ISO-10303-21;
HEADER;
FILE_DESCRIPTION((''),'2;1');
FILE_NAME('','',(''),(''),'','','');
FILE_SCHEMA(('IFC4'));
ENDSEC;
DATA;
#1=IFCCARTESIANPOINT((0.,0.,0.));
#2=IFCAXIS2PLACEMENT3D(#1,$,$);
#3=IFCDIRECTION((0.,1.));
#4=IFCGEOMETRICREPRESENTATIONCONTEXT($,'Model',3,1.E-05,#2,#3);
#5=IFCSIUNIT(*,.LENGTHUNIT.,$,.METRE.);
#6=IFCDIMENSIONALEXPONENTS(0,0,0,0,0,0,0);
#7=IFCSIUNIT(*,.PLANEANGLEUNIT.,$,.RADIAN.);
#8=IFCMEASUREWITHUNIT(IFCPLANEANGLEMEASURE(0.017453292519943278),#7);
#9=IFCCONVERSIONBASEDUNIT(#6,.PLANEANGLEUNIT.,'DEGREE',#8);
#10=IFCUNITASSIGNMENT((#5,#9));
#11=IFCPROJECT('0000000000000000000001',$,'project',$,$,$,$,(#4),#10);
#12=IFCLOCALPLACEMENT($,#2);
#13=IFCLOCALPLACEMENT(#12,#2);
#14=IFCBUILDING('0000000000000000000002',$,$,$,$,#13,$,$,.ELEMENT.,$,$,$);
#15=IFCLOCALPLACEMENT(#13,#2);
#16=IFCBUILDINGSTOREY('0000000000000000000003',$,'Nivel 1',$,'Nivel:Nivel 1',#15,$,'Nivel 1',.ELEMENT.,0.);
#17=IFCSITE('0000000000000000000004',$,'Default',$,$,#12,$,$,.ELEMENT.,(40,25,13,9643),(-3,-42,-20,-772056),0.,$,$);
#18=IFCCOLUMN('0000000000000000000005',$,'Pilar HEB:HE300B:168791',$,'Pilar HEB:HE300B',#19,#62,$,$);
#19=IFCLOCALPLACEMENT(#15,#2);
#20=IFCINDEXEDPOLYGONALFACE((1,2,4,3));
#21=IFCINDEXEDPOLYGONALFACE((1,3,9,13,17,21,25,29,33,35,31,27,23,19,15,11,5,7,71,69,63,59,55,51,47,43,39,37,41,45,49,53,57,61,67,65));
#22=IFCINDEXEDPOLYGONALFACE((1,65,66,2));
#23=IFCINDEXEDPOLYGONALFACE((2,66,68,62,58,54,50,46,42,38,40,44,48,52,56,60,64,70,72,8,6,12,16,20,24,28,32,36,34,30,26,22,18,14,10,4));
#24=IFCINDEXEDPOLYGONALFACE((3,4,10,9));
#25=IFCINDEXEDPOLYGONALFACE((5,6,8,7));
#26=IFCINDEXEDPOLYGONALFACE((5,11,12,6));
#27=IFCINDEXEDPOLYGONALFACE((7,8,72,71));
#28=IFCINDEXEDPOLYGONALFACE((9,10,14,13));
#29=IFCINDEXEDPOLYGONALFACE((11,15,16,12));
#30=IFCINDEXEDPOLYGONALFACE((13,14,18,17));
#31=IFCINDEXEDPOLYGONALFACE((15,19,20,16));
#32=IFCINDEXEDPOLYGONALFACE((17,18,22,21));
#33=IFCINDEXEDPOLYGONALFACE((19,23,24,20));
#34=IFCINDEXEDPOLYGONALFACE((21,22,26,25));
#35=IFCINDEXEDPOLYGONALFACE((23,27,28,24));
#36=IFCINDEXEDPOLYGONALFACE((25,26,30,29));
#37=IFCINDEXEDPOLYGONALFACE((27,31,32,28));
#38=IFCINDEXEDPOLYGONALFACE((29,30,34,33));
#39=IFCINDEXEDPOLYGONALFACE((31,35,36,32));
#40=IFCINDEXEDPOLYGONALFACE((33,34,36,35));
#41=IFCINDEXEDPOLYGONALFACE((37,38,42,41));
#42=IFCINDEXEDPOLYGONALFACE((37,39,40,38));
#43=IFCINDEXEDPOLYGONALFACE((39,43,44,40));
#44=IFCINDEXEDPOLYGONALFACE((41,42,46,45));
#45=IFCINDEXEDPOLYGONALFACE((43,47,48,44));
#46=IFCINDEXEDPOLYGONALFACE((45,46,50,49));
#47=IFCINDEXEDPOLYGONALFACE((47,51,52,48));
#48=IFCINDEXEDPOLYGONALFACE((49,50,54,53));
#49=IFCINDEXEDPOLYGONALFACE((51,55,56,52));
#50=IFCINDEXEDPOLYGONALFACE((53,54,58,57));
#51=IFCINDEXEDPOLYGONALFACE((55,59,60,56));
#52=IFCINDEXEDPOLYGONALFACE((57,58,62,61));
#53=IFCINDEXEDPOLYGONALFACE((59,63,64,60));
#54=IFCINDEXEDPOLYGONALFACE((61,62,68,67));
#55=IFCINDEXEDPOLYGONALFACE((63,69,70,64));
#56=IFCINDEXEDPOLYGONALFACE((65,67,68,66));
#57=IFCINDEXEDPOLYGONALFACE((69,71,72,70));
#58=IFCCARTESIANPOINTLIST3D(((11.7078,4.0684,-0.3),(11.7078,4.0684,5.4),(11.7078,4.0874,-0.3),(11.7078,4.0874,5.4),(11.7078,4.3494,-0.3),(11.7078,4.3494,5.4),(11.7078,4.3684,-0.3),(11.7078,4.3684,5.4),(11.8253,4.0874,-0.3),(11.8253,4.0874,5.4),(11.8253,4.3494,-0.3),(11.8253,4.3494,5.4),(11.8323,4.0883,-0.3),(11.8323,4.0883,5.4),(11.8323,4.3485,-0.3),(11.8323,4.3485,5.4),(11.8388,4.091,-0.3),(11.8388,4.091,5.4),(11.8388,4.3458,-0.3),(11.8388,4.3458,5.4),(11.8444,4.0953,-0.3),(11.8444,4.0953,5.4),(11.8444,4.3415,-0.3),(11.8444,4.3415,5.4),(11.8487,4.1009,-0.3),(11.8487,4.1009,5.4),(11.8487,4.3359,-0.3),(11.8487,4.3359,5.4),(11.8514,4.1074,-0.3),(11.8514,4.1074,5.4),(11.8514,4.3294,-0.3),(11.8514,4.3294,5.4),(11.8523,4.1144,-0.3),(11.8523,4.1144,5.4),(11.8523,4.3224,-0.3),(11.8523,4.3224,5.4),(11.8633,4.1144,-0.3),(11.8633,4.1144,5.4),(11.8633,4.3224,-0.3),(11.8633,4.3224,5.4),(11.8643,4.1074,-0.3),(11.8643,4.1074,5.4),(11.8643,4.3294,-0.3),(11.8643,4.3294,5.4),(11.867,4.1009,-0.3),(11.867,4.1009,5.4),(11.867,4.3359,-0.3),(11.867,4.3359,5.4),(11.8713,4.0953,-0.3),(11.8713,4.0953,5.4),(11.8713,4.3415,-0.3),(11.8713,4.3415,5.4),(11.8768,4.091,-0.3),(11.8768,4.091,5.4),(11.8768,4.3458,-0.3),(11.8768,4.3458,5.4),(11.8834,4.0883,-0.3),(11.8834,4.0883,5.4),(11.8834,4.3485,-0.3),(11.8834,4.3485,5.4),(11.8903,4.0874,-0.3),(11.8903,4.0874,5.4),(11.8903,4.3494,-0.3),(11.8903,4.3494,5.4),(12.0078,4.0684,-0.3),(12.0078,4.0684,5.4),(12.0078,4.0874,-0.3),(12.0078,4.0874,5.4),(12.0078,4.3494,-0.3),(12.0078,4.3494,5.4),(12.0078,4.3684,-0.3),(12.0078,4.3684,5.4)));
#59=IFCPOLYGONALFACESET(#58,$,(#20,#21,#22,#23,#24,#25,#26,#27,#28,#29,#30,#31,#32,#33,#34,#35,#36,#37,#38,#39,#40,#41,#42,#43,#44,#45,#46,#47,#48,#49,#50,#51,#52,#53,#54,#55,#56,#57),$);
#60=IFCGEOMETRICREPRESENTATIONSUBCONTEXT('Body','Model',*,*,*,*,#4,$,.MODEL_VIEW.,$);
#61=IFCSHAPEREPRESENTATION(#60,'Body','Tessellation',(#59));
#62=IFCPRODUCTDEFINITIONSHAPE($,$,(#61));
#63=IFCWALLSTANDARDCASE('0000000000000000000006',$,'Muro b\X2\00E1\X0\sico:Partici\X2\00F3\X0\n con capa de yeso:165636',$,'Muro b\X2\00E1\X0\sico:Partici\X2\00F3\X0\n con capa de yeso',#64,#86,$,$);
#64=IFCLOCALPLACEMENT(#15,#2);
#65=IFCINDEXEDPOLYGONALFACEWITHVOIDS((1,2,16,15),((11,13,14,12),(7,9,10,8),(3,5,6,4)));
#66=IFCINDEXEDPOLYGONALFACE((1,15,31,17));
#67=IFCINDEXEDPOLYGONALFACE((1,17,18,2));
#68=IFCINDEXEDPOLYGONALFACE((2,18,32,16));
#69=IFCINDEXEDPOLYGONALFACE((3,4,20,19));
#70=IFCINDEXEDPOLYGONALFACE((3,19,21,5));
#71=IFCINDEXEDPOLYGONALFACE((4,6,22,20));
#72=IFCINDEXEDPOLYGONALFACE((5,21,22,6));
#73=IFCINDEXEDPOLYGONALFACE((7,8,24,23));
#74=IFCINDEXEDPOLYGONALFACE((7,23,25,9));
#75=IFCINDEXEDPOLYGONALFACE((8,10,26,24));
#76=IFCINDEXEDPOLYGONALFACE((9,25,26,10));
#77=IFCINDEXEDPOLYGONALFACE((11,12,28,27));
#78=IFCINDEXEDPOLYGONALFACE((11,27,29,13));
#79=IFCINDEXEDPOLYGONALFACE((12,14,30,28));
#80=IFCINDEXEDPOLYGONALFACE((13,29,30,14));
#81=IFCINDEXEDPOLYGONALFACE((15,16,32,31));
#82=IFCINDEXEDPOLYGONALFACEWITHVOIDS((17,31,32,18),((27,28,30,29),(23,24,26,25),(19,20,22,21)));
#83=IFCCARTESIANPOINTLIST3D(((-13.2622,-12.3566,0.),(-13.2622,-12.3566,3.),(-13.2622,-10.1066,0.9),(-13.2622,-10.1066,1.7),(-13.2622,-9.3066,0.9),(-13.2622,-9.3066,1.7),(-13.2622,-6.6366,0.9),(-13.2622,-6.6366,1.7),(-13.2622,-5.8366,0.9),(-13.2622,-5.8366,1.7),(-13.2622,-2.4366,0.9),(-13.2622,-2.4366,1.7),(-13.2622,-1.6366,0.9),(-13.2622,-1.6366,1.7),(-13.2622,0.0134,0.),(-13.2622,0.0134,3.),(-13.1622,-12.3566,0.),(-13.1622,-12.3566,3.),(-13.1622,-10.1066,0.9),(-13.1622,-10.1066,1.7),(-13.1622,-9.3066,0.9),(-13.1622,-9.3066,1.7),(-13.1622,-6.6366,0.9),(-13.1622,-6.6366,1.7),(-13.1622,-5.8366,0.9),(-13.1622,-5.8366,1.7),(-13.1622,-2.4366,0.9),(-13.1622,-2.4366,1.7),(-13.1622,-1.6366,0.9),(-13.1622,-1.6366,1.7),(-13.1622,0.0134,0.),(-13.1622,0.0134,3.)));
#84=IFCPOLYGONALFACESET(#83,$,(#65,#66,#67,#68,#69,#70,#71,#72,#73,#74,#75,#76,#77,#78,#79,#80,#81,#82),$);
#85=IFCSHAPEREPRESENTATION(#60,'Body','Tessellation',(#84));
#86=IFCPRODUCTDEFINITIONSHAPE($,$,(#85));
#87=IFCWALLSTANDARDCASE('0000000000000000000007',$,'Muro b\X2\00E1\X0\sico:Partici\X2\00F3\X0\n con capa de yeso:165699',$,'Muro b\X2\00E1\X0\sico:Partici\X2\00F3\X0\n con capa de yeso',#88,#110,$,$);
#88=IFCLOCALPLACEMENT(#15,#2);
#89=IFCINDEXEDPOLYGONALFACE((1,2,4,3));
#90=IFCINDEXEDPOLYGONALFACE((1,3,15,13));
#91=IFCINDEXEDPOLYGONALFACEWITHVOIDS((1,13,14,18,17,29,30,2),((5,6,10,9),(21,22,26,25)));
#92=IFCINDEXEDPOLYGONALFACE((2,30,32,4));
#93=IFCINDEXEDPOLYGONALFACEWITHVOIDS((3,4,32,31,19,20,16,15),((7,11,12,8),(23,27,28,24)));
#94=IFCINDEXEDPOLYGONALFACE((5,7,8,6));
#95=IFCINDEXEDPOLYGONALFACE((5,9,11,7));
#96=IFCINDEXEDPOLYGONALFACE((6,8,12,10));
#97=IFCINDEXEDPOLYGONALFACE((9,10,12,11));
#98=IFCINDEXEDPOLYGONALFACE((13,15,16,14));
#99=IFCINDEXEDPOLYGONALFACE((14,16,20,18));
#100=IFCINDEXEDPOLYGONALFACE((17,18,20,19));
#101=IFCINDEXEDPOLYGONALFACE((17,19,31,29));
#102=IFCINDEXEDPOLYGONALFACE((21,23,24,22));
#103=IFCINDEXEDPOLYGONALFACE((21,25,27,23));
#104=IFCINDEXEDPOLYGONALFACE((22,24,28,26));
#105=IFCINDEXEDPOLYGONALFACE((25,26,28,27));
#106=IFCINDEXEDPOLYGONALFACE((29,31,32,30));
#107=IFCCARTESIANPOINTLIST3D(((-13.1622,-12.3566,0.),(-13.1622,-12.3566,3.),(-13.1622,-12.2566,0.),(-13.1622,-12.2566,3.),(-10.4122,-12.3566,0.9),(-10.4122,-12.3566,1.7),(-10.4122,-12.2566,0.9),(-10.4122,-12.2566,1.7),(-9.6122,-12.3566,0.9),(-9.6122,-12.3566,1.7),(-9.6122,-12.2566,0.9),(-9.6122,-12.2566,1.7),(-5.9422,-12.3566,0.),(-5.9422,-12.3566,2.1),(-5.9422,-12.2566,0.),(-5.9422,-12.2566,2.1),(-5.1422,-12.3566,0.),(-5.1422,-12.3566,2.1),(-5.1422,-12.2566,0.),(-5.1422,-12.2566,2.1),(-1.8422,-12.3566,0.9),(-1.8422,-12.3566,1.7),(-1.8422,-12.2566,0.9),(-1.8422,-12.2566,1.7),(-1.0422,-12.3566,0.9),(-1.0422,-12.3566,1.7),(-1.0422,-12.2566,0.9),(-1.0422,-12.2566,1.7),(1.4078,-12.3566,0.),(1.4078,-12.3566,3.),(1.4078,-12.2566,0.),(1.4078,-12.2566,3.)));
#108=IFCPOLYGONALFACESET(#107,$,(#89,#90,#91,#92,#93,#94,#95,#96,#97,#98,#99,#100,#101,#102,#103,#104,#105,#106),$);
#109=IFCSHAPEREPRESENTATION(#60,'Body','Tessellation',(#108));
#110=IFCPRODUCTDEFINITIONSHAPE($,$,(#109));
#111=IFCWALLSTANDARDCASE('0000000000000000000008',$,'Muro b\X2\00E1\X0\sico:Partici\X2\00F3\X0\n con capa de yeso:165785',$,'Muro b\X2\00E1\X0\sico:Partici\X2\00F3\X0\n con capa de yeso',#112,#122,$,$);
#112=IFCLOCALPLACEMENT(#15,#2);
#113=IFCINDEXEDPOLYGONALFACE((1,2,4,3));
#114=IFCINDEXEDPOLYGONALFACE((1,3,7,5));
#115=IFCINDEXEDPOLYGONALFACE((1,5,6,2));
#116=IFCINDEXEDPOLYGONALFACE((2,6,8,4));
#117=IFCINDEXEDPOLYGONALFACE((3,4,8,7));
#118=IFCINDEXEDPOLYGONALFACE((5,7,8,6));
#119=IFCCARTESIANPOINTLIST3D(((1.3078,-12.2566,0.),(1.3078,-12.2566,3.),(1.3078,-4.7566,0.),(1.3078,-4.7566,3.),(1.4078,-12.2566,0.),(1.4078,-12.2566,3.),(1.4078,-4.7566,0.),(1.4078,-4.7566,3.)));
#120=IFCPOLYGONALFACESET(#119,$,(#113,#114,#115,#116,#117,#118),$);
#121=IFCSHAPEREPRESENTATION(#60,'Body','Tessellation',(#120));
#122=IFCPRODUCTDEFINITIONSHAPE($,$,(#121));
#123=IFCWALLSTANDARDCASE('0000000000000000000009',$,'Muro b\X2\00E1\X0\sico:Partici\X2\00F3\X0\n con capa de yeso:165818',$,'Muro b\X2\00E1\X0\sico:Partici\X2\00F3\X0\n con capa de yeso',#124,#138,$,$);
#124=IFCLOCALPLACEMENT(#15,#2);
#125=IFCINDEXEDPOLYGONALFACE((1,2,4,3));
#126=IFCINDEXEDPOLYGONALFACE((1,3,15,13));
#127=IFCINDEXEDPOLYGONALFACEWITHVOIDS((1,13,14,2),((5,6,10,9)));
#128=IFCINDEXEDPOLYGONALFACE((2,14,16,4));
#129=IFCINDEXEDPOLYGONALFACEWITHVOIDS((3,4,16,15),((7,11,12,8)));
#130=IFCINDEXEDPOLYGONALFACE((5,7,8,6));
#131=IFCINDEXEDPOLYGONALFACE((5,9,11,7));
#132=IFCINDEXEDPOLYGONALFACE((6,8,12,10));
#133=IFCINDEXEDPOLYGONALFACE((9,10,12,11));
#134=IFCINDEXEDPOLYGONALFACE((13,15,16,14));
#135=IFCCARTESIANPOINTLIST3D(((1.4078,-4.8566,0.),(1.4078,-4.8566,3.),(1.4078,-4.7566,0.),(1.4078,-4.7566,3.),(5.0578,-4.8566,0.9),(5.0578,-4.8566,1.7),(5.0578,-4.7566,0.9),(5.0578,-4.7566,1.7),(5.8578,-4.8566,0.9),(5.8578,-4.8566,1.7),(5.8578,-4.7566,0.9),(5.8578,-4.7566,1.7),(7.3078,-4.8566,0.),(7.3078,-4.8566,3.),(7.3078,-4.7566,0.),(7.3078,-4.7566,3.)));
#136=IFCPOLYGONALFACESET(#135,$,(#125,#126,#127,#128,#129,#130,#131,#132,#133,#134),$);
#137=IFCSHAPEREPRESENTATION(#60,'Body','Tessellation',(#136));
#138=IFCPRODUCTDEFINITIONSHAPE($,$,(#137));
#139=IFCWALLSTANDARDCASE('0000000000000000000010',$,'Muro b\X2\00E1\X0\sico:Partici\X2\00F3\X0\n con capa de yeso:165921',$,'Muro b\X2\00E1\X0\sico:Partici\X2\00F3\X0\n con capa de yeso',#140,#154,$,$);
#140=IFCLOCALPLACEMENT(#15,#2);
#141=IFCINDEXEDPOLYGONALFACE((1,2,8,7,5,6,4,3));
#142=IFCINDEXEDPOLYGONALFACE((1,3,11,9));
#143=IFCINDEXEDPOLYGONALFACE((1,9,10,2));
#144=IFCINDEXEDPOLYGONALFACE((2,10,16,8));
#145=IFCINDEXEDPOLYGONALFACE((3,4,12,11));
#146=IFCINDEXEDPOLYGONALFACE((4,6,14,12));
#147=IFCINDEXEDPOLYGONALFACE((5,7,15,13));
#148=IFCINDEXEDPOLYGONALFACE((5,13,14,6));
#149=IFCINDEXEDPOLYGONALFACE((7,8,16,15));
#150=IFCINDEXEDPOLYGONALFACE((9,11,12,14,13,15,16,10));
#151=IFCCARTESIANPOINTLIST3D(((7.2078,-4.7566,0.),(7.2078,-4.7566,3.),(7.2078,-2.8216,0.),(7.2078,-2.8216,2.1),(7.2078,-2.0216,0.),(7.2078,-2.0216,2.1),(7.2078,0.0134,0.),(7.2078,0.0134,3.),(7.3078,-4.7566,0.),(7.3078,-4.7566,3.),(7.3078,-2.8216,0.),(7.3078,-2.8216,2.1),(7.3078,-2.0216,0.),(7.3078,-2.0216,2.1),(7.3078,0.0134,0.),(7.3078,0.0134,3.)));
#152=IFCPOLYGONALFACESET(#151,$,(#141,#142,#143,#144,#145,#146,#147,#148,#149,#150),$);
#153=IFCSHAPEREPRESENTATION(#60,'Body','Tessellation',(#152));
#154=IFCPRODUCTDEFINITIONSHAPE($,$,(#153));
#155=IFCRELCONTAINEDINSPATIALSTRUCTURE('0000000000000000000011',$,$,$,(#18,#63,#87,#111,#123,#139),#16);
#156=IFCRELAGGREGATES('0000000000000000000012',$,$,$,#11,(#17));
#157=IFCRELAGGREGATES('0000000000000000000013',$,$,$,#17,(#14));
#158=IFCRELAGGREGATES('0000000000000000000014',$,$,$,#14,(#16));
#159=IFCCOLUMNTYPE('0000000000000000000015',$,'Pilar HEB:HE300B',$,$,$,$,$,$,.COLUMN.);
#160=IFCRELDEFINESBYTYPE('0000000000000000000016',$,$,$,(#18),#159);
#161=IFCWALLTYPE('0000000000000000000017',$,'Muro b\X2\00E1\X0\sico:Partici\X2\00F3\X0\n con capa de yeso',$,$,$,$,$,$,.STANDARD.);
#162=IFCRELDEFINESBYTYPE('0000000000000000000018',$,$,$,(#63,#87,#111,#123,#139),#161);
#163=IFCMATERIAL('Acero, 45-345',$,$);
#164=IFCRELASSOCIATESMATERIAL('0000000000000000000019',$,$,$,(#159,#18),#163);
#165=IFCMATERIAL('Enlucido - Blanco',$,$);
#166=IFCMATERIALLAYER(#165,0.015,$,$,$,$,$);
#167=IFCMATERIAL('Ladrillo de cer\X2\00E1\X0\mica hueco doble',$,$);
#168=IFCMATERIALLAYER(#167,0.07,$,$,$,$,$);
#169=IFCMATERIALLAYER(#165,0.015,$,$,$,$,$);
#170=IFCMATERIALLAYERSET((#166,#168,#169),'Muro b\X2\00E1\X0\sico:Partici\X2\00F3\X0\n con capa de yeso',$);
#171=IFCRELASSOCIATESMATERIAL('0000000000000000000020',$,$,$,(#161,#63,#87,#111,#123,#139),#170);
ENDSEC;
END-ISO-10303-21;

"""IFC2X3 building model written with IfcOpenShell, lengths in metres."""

from ifc_helpers import new_model, entity, si_unit, converted_unit, direction, frame, frame_2d, origin, place, context, subcontext, project, spatial, rectangle, i_section, extrude, source, transform, mapped, material, layer, layer_set, layer_usage, type_object, type_shapes, element, save


model = new_model("IFC2X3")

# Units and contexts
model_context = context("Model", 3, precision=1e-05, world=origin(), true_north=direction((0.0, 1.0)))
body_context = subcontext(model_context, "Body", "Model", "MODEL_VIEW")
ifc_project = project(units=[si_unit("LENGTHUNIT", "METRE"), converted_unit("PLANEANGLEUNIT", "DEGREE", entity("IfcPlaneAngleMeasure", 0.017453292519943278), si_unit("PLANEANGLEUNIT", "RADIAN"), dimensions=[0, 0, 0, 0, 0, 0, 0])], contexts=[model_context])

# Site, building, storey
site_placement = place(None, origin())
site = spatial("IfcSite", under=ifc_project, at=site_placement, Name="Default", CompositionType="ELEMENT", RefLatitude=(40, 25, 13, 9643), RefLongitude=(-3, -42, -20, -772056), RefElevation=0.0)
building_placement = place(site_placement, origin())
building = spatial("IfcBuilding", under=site, at=building_placement, CompositionType="ELEMENT")
storey_placement = place(building_placement, origin())
storey = spatial("IfcBuildingStorey", under=building, at=storey_placement, Name="Nivel 1", ObjectType="Nivel:Nivel 1", LongName="Nivel 1", CompositionType="ELEMENT", Elevation=0.0)

# Column
ifc_material_1 = material(Name="Acero, 45-345")
column_type_1 = type_object("IfcColumnType", Name="Pilar HEB:HE300B", PredefinedType="COLUMN", material=ifc_material_1)
shared_shape_1 = source(origin(), body_context, "Body", "SweptSolid", [
    extrude(i_section(OverallWidth=0.3, OverallDepth=0.3, WebThickness=0.011, FlangeThickness=0.019, FilletRadius=0.027, at=frame_2d((0.0, 0.0), x_axis=(1.0, 0.0))), frame((11.8578, 4.2184, -0.3), z_axis=(0.0, 0.0, 1.0), x_axis=(-1.0, 0.0, 0.0)), (0.0, 0.0, 1.0), 5.7),
])
type_shapes(column_type_1, [shared_shape_1])
column_1_placement = place(storey_placement, origin())
element("IfcColumn", 1, at=column_1_placement, inside=storey, type_object=column_type_1, material=ifc_material_1, Name="Pilar HEB:HE300B:168791", ObjectType="Pilar HEB:HE300B", context=body_context, shape_type="MappedRepresentation", body=[
    mapped(shared_shape_1, transform((0.0, 0.0, 0.0), scale=1.0)),
])

# Walls, openings
ifc_material_2 = material(Name="Enlucido - Blanco")
ifc_layer_1 = layer(ifc_material_2, 0.015)
ifc_material_3 = material(Name="Ladrillo de cerámica hueco doble")
ifc_layer_2 = layer(ifc_material_3, 0.07)
ifc_layer_3 = layer(ifc_material_2, 0.015)
ifc_layer_set_1 = layer_set([ifc_layer_1, ifc_layer_2, ifc_layer_3], Name="Muro básico:Partición con capa de yeso")
ifc_layer_usage_1 = layer_usage(ifc_layer_set_1, "AXIS2", "NEGATIVE", 0.05)
wall_type = type_object("IfcWallType", Name="Muro básico:Partición con capa de yeso", PredefinedType="STANDARD", material=ifc_layer_set_1)
wall_1_placement = place(storey_placement, frame((-13.2122, 0.0134, 0.0), z_axis=(0.0, 0.0, 1.0), x_axis=(0.0, -1.0, 0.0)))
wall_1 = element("IfcWallStandardCase", 2, at=wall_1_placement, inside=storey, type_object=wall_type, material=ifc_layer_usage_1, Name="Muro básico:Partición con capa de yeso:165636", ObjectType="Muro básico:Partición con capa de yeso", context=body_context, shape_type="SweptSolid", body=[
    extrude(rectangle(XDim=12.37, YDim=0.1, at=frame_2d((6.185, 0.0), x_axis=(-1.0, 0.0))), origin(), (0.0, 0.0, 1.0), 3.0),
])
opening_1_placement = place(wall_1_placement, frame((1.65, -0.05, 0.9)))
element("IfcOpeningElement", 3, at=opening_1_placement, cuts=wall_1, ObjectType="Opening", context=body_context, shape_type="SweptSolid", body=[
    extrude(rectangle(XDim=0.8, YDim=0.8, at=frame_2d((0.4, 0.4), x_axis=(1.0, 0.0))), frame((0.0, 0.0, 0.0), z_axis=(0.0, 1.0, 0.0), x_axis=(0.0, 0.0, 1.0)), (0.0, 0.0, 1.0), 0.1),
])
opening_2_placement = place(wall_1_placement, frame((6.65, 0.05, 0.9)))
element("IfcOpeningElement", 4, at=opening_2_placement, cuts=wall_1, ObjectType="Opening", context=body_context, shape_type="SweptSolid", body=[
    extrude(rectangle(XDim=0.8, YDim=0.8, at=frame_2d((0.4, 0.4), x_axis=(1.0, 0.0))), frame((0.0, 0.0, 0.0), z_axis=(0.0, -1.0, 0.0), x_axis=(0.0, 0.0, 1.0)), (0.0, 0.0, 1.0), 0.1),
])
opening_3_placement = place(wall_1_placement, frame((9.32, -0.05, 0.9)))
element("IfcOpeningElement", 5, at=opening_3_placement, cuts=wall_1, ObjectType="Opening", context=body_context, shape_type="SweptSolid", body=[
    extrude(rectangle(XDim=0.8, YDim=0.8, at=frame_2d((0.4, 0.4), x_axis=(1.0, 0.0))), frame((0.0, 0.0, 0.0), z_axis=(0.0, 1.0, 0.0), x_axis=(0.0, 0.0, 1.0)), (0.0, 0.0, 1.0), 0.1),
])
ifc_layer_usage_2 = layer_usage(ifc_layer_set_1, "AXIS2", "NEGATIVE", 0.05)
wall_2_placement = place(storey_placement, frame((-13.1622, -12.3066, 0.0)))
wall_2 = element("IfcWallStandardCase", 6, at=wall_2_placement, inside=storey, type_object=wall_type, material=ifc_layer_usage_2, Name="Muro básico:Partición con capa de yeso:165699", ObjectType="Muro básico:Partición con capa de yeso", context=body_context, shape_type="SweptSolid", body=[
    extrude(rectangle(XDim=14.57, YDim=0.1, at=frame_2d((7.285, 0.0), x_axis=(1.0, 0.0))), origin(), (0.0, 0.0, 1.0), 3.0),
])
opening_4_placement = place(wall_2_placement, frame((8.02, 0.05, 0.0)))
element("IfcOpeningElement", 7, at=opening_4_placement, cuts=wall_2, ObjectType="Opening", context=body_context, shape_type="SweptSolid", body=[
    extrude(rectangle(XDim=2.1, YDim=0.8, at=frame_2d((1.05, 0.4), x_axis=(1.0, 0.0))), frame((0.0, 0.0, 0.0), z_axis=(0.0, -1.0, 0.0), x_axis=(0.0, 0.0, 1.0)), (0.0, 0.0, 1.0), 0.1),
])
opening_5_placement = place(wall_2_placement, frame((12.12, 0.05, 0.9)))
element("IfcOpeningElement", 8, at=opening_5_placement, cuts=wall_2, ObjectType="Opening", context=body_context, shape_type="SweptSolid", body=[
    extrude(rectangle(XDim=0.8, YDim=0.8, at=frame_2d((0.4, 0.4), x_axis=(1.0, 0.0))), frame((0.0, 0.0, 0.0), z_axis=(0.0, -1.0, 0.0), x_axis=(0.0, 0.0, 1.0)), (0.0, 0.0, 1.0), 0.1),
])
opening_6_placement = place(wall_2_placement, frame((3.55, 0.05, 0.9)))
element("IfcOpeningElement", 9, at=opening_6_placement, cuts=wall_2, ObjectType="Opening", context=body_context, shape_type="SweptSolid", body=[
    extrude(rectangle(XDim=0.8, YDim=0.8, at=frame_2d((0.4, 0.4), x_axis=(1.0, 0.0))), frame((0.0, 0.0, 0.0), z_axis=(0.0, -1.0, 0.0), x_axis=(0.0, 0.0, 1.0)), (0.0, 0.0, 1.0), 0.1),
])

# Wall
ifc_layer_usage_3 = layer_usage(ifc_layer_set_1, "AXIS2", "NEGATIVE", 0.05)
wall_3_placement = place(storey_placement, frame((1.3578, -12.2566, 0.0), z_axis=(0.0, 0.0, 1.0), x_axis=(0.0, 1.0, 0.0)))
element("IfcWallStandardCase", 10, at=wall_3_placement, inside=storey, type_object=wall_type, material=ifc_layer_usage_3, Name="Muro básico:Partición con capa de yeso:165785", ObjectType="Muro básico:Partición con capa de yeso", context=body_context, shape_type="SweptSolid", body=[
    extrude(rectangle(XDim=7.5, YDim=0.1, at=frame_2d((3.75, 0.0), x_axis=(-1.0, 0.0))), origin(), (0.0, 0.0, 1.0), 3.0),
])

# Walls, openings
ifc_layer_usage_4 = layer_usage(ifc_layer_set_1, "AXIS2", "NEGATIVE", 0.05)
wall_4_placement = place(storey_placement, frame((1.4078, -4.8066, 0.0)))
wall_4 = element("IfcWallStandardCase", 11, at=wall_4_placement, inside=storey, type_object=wall_type, material=ifc_layer_usage_4, Name="Muro básico:Partición con capa de yeso:165818", ObjectType="Muro básico:Partición con capa de yeso", context=body_context, shape_type="SweptSolid", body=[
    extrude(rectangle(XDim=5.9, YDim=0.1, at=frame_2d((2.95, 0.0), x_axis=(-1.0, 0.0))), origin(), (0.0, 0.0, 1.0), 3.0),
])
opening_7_placement = place(wall_4_placement, frame((3.65, -0.05, 0.9)))
element("IfcOpeningElement", 12, at=opening_7_placement, cuts=wall_4, ObjectType="Opening", context=body_context, shape_type="SweptSolid", body=[
    extrude(rectangle(XDim=0.8, YDim=0.8, at=frame_2d((0.4, 0.4), x_axis=(1.0, 0.0))), frame((0.0, 0.0, 0.0), z_axis=(0.0, 1.0, 0.0), x_axis=(0.0, 0.0, 1.0)), (0.0, 0.0, 1.0), 0.1),
])
ifc_layer_usage_5 = layer_usage(ifc_layer_set_1, "AXIS2", "NEGATIVE", 0.05)
wall_5_placement = place(storey_placement, frame((7.2578, -4.7566, 0.0), z_axis=(0.0, 0.0, 1.0), x_axis=(0.0, 1.0, 0.0)))
wall_5 = element("IfcWallStandardCase", 13, at=wall_5_placement, inside=storey, type_object=wall_type, material=ifc_layer_usage_5, Name="Muro básico:Partición con capa de yeso:165921", ObjectType="Muro básico:Partición con capa de yeso", context=body_context, shape_type="SweptSolid", body=[
    extrude(rectangle(XDim=4.77, YDim=0.1, at=frame_2d((2.385, 0.0), x_axis=(-1.0, 0.0))), origin(), (0.0, 0.0, 1.0), 3.0),
])
opening_8_placement = place(wall_5_placement, frame((2.735, 0.05, 0.0)))
element("IfcOpeningElement", 14, at=opening_8_placement, cuts=wall_5, ObjectType="Opening", context=body_context, shape_type="SweptSolid", body=[
    extrude(rectangle(XDim=2.1, YDim=0.8, at=frame_2d((1.05, 0.4), x_axis=(1.0, 0.0))), frame((0.0, 0.0, 0.0), z_axis=(0.0, -1.0, 0.0), x_axis=(0.0, 0.0, 1.0)), (0.0, 0.0, 1.0), 0.1),
])

save(model, "model.ifc")
